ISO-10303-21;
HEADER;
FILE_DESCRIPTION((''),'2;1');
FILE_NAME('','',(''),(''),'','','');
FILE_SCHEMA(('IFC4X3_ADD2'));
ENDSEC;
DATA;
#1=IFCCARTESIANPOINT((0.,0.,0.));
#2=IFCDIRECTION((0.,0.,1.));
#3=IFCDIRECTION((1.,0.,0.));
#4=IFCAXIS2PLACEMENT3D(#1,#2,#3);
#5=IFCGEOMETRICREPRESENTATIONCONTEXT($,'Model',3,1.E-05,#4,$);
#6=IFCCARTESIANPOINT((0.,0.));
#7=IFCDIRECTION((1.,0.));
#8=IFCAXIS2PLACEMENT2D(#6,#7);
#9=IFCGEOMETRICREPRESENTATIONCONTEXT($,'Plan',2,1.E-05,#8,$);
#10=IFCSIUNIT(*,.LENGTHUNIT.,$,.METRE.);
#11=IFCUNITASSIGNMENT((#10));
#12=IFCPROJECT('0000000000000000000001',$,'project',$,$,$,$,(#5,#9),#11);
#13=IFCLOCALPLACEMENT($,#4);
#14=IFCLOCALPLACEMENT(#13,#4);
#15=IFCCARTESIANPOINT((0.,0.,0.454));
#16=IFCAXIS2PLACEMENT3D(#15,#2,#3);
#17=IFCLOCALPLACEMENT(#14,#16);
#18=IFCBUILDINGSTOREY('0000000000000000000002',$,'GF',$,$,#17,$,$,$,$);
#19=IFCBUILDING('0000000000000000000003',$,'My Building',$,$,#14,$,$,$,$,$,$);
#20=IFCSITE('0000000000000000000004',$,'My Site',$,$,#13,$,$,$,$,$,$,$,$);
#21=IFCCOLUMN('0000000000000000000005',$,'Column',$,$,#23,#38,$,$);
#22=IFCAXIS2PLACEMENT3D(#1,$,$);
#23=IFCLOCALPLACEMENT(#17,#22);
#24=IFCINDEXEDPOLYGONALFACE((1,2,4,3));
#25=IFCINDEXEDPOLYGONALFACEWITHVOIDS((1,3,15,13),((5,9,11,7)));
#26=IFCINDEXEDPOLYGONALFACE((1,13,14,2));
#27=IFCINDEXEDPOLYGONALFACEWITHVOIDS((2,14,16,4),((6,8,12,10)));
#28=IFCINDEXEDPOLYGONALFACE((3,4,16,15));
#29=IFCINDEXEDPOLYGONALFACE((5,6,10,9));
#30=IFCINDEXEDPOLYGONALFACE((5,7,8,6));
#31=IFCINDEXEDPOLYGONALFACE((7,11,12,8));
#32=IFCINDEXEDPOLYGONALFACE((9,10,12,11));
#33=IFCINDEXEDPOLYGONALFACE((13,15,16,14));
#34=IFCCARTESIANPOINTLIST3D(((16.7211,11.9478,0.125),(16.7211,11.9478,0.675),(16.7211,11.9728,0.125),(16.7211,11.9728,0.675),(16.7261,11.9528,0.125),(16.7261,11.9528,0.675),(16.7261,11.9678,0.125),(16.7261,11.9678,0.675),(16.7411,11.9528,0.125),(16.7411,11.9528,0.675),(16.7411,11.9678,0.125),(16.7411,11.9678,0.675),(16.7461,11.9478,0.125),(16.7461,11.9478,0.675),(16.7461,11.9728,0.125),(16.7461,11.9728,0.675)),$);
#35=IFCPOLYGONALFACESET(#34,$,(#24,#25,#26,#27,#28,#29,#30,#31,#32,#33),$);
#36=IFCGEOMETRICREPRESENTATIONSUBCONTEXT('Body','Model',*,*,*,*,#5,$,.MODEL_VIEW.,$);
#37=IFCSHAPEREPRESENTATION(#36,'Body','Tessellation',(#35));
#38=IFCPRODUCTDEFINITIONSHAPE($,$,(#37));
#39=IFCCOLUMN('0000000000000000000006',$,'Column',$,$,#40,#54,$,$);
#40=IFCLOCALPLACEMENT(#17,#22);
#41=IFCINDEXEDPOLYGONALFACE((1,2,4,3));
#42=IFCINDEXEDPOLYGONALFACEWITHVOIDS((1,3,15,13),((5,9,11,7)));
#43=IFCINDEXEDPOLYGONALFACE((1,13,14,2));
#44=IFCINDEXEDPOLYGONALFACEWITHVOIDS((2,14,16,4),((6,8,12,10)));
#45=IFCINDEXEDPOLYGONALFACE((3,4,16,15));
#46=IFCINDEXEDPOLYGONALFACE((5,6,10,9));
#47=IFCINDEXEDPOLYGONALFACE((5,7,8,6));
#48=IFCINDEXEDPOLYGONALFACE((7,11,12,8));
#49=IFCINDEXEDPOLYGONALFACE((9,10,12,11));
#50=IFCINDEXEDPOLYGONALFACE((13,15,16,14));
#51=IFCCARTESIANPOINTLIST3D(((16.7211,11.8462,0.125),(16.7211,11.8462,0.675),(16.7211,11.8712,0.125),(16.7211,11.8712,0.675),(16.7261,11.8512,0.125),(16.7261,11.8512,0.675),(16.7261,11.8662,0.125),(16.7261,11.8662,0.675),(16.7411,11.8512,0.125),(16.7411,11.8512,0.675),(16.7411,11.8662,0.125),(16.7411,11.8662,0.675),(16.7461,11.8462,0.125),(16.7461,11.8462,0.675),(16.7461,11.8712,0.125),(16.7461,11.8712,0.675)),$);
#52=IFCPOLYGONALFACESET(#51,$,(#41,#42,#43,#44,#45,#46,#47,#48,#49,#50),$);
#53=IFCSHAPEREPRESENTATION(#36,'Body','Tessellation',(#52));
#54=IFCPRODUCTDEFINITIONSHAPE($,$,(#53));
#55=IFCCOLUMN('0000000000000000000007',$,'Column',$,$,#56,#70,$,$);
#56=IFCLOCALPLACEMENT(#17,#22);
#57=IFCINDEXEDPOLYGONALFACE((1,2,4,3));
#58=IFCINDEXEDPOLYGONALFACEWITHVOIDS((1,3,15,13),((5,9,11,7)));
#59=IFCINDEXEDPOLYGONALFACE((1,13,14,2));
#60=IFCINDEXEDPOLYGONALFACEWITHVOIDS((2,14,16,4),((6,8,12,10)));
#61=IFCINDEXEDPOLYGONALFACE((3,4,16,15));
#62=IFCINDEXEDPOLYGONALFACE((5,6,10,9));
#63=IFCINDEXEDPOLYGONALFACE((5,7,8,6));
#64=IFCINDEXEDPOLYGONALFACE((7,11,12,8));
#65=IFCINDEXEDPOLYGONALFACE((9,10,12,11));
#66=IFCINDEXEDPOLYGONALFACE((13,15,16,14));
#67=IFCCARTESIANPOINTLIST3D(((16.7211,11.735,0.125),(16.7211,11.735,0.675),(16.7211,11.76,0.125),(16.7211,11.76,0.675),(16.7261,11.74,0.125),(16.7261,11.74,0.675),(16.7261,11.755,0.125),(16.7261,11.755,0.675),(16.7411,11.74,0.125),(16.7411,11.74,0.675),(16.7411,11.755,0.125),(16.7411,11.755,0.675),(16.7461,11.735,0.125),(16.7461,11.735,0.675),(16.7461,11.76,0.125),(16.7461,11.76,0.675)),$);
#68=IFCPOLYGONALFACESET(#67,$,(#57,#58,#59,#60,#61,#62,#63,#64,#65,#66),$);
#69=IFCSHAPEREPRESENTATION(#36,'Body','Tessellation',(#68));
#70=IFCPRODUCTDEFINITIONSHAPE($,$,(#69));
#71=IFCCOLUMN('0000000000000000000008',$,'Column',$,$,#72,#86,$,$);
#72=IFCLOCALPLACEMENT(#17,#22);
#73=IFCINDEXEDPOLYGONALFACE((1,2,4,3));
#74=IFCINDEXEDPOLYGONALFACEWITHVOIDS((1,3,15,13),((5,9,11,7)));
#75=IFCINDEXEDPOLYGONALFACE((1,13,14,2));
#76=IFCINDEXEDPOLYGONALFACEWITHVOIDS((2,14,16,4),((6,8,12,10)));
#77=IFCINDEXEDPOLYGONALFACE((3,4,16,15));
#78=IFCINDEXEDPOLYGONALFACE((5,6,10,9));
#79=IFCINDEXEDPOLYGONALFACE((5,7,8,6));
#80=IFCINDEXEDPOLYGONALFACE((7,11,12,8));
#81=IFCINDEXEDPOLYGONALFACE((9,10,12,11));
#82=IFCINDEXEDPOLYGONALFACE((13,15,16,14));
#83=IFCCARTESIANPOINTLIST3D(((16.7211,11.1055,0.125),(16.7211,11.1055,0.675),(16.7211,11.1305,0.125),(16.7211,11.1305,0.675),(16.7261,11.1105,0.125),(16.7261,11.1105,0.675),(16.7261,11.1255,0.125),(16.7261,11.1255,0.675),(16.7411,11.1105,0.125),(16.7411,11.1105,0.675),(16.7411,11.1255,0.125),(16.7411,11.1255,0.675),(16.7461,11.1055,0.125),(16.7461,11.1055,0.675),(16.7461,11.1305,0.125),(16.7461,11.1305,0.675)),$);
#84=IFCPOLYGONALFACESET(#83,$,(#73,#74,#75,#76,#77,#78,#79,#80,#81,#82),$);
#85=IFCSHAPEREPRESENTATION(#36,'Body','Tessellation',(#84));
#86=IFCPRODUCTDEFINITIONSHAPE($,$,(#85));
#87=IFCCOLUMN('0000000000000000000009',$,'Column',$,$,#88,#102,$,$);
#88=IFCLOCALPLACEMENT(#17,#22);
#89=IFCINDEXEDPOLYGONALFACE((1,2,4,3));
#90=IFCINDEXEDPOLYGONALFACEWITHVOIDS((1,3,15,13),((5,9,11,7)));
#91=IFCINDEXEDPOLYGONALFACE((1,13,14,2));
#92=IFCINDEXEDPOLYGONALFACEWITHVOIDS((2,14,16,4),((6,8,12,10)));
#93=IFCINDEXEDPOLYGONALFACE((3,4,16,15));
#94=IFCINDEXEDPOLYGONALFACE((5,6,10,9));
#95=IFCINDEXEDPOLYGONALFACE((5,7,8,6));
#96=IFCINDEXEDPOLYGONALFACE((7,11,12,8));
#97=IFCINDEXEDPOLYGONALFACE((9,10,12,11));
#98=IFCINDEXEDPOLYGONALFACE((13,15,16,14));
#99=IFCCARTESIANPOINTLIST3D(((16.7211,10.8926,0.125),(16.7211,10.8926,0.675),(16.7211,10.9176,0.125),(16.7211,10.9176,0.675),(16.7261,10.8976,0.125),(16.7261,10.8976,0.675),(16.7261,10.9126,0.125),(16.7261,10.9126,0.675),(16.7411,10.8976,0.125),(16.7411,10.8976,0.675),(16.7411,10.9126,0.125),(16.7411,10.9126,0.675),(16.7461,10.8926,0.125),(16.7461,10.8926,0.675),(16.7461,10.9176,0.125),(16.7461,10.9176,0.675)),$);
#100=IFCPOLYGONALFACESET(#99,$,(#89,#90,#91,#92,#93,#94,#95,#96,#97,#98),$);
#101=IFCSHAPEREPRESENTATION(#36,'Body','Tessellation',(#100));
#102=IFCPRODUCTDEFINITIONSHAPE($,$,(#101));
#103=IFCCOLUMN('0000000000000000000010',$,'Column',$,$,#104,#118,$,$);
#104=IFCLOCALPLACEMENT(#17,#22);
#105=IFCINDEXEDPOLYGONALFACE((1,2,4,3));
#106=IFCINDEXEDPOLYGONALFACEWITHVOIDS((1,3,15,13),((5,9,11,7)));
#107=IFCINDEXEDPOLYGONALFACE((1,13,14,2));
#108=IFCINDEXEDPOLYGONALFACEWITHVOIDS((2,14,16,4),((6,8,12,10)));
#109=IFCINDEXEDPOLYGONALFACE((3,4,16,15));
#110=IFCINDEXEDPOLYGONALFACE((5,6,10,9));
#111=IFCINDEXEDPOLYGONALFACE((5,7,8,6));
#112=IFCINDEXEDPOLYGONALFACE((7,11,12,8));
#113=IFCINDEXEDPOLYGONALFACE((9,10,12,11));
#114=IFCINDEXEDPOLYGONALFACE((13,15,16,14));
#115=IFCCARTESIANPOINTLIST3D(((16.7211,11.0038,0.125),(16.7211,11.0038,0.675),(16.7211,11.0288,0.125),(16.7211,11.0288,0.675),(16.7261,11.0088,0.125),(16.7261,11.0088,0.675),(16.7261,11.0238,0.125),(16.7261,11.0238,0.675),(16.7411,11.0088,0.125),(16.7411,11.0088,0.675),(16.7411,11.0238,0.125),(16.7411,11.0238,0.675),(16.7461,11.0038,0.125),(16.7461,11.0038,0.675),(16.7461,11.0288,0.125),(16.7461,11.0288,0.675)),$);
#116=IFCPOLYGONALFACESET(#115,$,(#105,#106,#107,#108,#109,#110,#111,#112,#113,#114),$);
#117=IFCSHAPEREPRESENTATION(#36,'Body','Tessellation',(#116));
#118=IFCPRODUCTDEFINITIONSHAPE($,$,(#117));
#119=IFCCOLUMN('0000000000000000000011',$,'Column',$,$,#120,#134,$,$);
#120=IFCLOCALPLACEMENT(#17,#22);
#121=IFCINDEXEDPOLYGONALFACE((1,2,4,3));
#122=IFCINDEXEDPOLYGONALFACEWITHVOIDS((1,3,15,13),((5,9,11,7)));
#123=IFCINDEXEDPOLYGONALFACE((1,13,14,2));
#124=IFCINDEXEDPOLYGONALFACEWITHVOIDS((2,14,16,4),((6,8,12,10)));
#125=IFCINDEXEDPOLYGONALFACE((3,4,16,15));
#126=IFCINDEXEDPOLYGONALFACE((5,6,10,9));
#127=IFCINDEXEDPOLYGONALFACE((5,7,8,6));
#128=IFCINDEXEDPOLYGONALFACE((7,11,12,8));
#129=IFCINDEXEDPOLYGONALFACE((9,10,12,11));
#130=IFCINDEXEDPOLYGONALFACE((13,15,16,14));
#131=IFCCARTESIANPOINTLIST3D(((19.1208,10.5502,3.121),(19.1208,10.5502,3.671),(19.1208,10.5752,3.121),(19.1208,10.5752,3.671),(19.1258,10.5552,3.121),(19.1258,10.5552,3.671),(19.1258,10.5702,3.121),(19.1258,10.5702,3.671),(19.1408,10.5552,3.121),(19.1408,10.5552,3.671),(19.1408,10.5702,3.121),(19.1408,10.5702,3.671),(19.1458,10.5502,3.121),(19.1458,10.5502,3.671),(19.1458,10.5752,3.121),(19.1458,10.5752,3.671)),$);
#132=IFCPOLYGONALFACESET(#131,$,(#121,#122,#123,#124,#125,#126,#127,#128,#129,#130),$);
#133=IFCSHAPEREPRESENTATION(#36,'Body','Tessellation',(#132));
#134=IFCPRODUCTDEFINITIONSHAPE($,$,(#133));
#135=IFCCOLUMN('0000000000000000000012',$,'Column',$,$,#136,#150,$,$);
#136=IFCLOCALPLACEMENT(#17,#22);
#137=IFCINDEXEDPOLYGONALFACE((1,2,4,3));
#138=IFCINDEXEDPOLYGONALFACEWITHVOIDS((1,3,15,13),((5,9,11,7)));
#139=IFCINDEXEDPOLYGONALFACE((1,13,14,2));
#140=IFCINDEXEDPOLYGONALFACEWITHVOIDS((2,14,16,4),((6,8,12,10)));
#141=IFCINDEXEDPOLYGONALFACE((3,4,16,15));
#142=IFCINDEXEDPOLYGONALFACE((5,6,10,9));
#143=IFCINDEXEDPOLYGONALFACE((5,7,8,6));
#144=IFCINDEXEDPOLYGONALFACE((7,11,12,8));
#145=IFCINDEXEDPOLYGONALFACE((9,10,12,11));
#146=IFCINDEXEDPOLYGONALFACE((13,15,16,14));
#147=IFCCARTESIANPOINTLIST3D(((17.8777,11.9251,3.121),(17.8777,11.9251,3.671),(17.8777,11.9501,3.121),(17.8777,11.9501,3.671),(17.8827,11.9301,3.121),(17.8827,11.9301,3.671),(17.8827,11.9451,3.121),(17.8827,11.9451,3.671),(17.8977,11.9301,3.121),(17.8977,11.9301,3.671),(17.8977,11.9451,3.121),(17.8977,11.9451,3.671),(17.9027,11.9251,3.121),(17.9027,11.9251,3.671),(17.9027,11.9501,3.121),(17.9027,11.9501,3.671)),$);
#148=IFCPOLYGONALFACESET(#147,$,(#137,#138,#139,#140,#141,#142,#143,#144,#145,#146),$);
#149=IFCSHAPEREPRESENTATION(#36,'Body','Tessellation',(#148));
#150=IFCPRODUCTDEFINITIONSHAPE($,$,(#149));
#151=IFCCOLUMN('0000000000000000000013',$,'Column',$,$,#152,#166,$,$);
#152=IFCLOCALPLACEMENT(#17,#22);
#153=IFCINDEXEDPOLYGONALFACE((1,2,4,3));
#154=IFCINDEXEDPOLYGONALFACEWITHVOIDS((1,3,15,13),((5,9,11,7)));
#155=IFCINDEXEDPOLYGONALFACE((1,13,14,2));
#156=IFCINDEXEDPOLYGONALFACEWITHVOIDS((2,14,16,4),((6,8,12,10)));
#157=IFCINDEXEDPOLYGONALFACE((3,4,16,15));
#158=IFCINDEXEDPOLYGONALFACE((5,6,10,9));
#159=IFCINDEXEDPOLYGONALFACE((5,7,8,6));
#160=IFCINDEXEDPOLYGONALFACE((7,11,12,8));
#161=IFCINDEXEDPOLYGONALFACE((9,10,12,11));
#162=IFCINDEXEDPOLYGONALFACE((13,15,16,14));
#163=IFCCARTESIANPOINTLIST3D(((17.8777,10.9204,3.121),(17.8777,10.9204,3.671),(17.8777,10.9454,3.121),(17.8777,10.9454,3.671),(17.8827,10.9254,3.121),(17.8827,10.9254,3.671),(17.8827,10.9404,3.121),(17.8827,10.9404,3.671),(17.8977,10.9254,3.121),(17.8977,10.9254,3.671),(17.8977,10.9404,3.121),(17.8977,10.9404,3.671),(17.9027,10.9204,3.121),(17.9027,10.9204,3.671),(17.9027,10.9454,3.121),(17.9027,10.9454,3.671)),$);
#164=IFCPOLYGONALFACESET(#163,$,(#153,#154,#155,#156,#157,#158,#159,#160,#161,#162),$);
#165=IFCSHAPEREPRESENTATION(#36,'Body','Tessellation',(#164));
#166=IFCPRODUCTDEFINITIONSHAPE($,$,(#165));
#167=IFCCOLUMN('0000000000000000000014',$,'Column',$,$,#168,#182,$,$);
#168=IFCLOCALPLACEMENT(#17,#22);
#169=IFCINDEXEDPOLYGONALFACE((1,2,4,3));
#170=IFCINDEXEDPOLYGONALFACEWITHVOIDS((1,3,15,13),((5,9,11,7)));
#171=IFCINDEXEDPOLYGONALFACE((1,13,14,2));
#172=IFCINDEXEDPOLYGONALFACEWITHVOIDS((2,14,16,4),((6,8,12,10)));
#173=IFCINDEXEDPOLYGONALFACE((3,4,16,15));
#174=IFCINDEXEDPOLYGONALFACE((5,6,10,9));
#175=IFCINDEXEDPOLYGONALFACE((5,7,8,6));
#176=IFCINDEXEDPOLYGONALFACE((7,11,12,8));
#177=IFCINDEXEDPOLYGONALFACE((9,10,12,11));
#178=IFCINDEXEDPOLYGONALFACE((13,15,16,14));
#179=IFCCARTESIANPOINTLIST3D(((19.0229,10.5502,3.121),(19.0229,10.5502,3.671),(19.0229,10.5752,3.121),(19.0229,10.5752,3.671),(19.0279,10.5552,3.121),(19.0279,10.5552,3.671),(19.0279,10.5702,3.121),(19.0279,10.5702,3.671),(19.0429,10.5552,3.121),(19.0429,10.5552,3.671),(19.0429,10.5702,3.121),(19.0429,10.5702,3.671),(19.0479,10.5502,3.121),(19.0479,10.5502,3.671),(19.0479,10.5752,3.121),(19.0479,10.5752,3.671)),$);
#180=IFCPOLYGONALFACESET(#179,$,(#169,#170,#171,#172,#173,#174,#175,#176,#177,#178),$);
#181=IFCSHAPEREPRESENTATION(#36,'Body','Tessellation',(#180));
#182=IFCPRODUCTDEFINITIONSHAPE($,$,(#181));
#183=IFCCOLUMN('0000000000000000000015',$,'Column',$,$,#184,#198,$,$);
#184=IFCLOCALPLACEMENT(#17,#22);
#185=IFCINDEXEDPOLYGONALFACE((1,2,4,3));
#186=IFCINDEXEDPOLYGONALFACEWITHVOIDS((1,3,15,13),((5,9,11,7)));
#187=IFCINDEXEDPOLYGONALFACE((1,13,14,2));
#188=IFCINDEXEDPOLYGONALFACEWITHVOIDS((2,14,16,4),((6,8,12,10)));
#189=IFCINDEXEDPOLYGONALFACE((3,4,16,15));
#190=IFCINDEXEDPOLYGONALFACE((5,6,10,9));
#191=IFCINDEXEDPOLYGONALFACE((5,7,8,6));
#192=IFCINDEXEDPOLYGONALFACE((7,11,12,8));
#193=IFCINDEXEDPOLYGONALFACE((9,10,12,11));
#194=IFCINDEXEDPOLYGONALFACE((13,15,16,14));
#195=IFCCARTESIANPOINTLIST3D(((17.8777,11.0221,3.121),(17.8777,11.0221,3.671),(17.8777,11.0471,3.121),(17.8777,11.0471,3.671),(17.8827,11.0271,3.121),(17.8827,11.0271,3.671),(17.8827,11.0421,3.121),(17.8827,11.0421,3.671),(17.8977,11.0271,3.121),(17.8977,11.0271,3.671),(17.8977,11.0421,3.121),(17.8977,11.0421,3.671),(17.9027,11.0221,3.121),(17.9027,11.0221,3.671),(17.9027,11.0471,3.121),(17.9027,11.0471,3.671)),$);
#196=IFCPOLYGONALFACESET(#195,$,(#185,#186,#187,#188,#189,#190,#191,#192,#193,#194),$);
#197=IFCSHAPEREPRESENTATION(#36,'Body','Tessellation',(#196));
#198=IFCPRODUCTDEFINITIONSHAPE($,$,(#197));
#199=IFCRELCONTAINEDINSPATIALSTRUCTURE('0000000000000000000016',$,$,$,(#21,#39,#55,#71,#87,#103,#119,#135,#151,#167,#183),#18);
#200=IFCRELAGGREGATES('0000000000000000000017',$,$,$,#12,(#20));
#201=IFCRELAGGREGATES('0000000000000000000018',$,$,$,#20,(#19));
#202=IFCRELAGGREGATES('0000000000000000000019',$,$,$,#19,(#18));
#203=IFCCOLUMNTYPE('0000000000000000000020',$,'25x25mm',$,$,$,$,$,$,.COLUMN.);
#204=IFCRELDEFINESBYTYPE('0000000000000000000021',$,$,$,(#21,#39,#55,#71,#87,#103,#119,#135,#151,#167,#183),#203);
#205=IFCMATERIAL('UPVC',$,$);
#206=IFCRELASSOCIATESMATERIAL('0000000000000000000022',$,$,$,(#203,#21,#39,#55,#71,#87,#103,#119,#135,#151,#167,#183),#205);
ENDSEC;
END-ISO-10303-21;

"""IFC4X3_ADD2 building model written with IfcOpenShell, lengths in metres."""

from ifc_helpers import new_model, si_unit, frame, origin_with_axes, origin_2d_with_axis, place, context, subcontext, project, spatial, hollow_rectangle, extrude, material, material_profile, profile_set, profile_usage, type_object, element, save


model = new_model("IFC4X3_ADD2")

# Units and contexts
model_context = context("Model", 3, precision=1e-05, world=origin_with_axes())
plan_context = context("Plan", 2, precision=1e-05, world=origin_2d_with_axis())
body_context = subcontext(model_context, "Body", "Model", "MODEL_VIEW")
ifc_project = project(units=[si_unit("LENGTHUNIT", "METRE")], contexts=[model_context, plan_context])

# Site, building, storey
site_placement = place(None, origin_with_axes())
site = spatial("IfcSite", under=ifc_project, at=site_placement, Name="My Site")
building_placement = place(site_placement, origin_with_axes())
building = spatial("IfcBuilding", under=site, at=building_placement, Name="My Building")
storey_placement = place(building_placement, frame((0.0, 0.0, 0.454), z_axis=(0.0, 0.0, 1.0), x_axis=(1.0, 0.0, 0.0)))
storey = spatial("IfcBuildingStorey", under=building, at=storey_placement, Name="GF")

# Columns
ifc_material_1 = material(Name="UPVC")
ifc_material_profile_1 = material_profile(ifc_material_1, hollow_rectangle(XDim=0.025, YDim=0.025, WallThickness=0.005))
ifc_profile_set_1 = profile_set([ifc_material_profile_1])
ifc_profile_usage_1 = profile_usage(ifc_profile_set_1)
column_type_1 = type_object("IfcColumnType", Name="25x25mm", PredefinedType="COLUMN", material=ifc_profile_set_1)
column_1_placement = place(storey_placement, frame((16.7336, 11.9603, 0.125), z_axis=(0.0, 0.0, 1.0), x_axis=(0.0, -1.0, 0.0)))
element("IfcColumn", 1, at=column_1_placement, inside=storey, type_object=column_type_1, material=ifc_profile_usage_1, Name="Column", context=body_context, shape_type="SweptSolid", body=[
    extrude(hollow_rectangle(XDim=0.025, YDim=0.025, WallThickness=0.005), origin_with_axes(), (0.0, 0.0, 1.0), 0.55),
])
ifc_profile_usage_2 = profile_usage(ifc_profile_set_1)
column_2_placement = place(storey_placement, frame((16.7336, 11.8587, 0.125), z_axis=(0.0, 0.0, 1.0), x_axis=(0.0, -1.0, 0.0)))
element("IfcColumn", 2, at=column_2_placement, inside=storey, type_object=column_type_1, material=ifc_profile_usage_2, Name="Column", context=body_context, shape_type="SweptSolid", body=[
    extrude(hollow_rectangle(XDim=0.025, YDim=0.025, WallThickness=0.005), origin_with_axes(), (0.0, 0.0, 1.0), 0.55),
])
ifc_profile_usage_3 = profile_usage(ifc_profile_set_1)
column_3_placement = place(storey_placement, frame((16.7336, 11.7475, 0.125), z_axis=(0.0, 0.0, 1.0), x_axis=(0.0, -1.0, 0.0)))
element("IfcColumn", 3, at=column_3_placement, inside=storey, type_object=column_type_1, material=ifc_profile_usage_3, Name="Column", context=body_context, shape_type="SweptSolid", body=[
    extrude(hollow_rectangle(XDim=0.025, YDim=0.025, WallThickness=0.005), origin_with_axes(), (0.0, 0.0, 1.0), 0.55),
])
ifc_profile_usage_4 = profile_usage(ifc_profile_set_1)
column_4_placement = place(storey_placement, frame((16.7336, 11.118, 0.125), z_axis=(0.0, 0.0, 1.0), x_axis=(0.0, -1.0, 0.0)))
element("IfcColumn", 4, at=column_4_placement, inside=storey, type_object=column_type_1, material=ifc_profile_usage_4, Name="Column", context=body_context, shape_type="SweptSolid", body=[
    extrude(hollow_rectangle(XDim=0.025, YDim=0.025, WallThickness=0.005), origin_with_axes(), (0.0, 0.0, 1.0), 0.55),
])
ifc_profile_usage_5 = profile_usage(ifc_profile_set_1)
column_5_placement = place(storey_placement, frame((16.7336, 10.9051, 0.125), z_axis=(0.0, 0.0, 1.0), x_axis=(0.0, -1.0, 0.0)))
element("IfcColumn", 5, at=column_5_placement, inside=storey, type_object=column_type_1, material=ifc_profile_usage_5, Name="Column", context=body_context, shape_type="SweptSolid", body=[
    extrude(hollow_rectangle(XDim=0.025, YDim=0.025, WallThickness=0.005), origin_with_axes(), (0.0, 0.0, 1.0), 0.55),
])
ifc_profile_usage_6 = profile_usage(ifc_profile_set_1)
column_6_placement = place(storey_placement, frame((16.7336, 11.0163, 0.125), z_axis=(0.0, 0.0, 1.0), x_axis=(0.0, -1.0, 0.0)))
element("IfcColumn", 6, at=column_6_placement, inside=storey, type_object=column_type_1, material=ifc_profile_usage_6, Name="Column", context=body_context, shape_type="SweptSolid", body=[
    extrude(hollow_rectangle(XDim=0.025, YDim=0.025, WallThickness=0.005), origin_with_axes(), (0.0, 0.0, 1.0), 0.55),
])
ifc_profile_usage_7 = profile_usage(ifc_profile_set_1)
column_7_placement = place(storey_placement, frame((19.1333, 10.5627, 3.121), z_axis=(0.0, 0.0, 1.0), x_axis=(0.0, -1.0, 0.0)))
element("IfcColumn", 7, at=column_7_placement, inside=storey, type_object=column_type_1, material=ifc_profile_usage_7, Name="Column", context=body_context, shape_type="SweptSolid", body=[
    extrude(hollow_rectangle(XDim=0.025, YDim=0.025, WallThickness=0.005), origin_with_axes(), (0.0, 0.0, 1.0), 0.55),
])
ifc_profile_usage_8 = profile_usage(ifc_profile_set_1)
column_8_placement = place(storey_placement, frame((17.8902, 11.9376, 3.121), z_axis=(0.0, 0.0, 1.0), x_axis=(0.0, -1.0, 0.0)))
element("IfcColumn", 8, at=column_8_placement, inside=storey, type_object=column_type_1, material=ifc_profile_usage_8, Name="Column", context=body_context, shape_type="SweptSolid", body=[
    extrude(hollow_rectangle(XDim=0.025, YDim=0.025, WallThickness=0.005), origin_with_axes(), (0.0, 0.0, 1.0), 0.55),
])
ifc_profile_usage_9 = profile_usage(ifc_profile_set_1)
column_9_placement = place(storey_placement, frame((17.8902, 10.9329, 3.121), z_axis=(0.0, 0.0, 1.0), x_axis=(0.0, -1.0, 0.0)))
element("IfcColumn", 9, at=column_9_placement, inside=storey, type_object=column_type_1, material=ifc_profile_usage_9, Name="Column", context=body_context, shape_type="SweptSolid", body=[
    extrude(hollow_rectangle(XDim=0.025, YDim=0.025, WallThickness=0.005), origin_with_axes(), (0.0, 0.0, 1.0), 0.55),
])
ifc_profile_usage_10 = profile_usage(ifc_profile_set_1)
column_10_placement = place(storey_placement, frame((19.0354, 10.5627, 3.121), z_axis=(0.0, 0.0, 1.0), x_axis=(0.0, -1.0, 0.0)))
element("IfcColumn", 10, at=column_10_placement, inside=storey, type_object=column_type_1, material=ifc_profile_usage_10, Name="Column", context=body_context, shape_type="SweptSolid", body=[
    extrude(hollow_rectangle(XDim=0.025, YDim=0.025, WallThickness=0.005), origin_with_axes(), (0.0, 0.0, 1.0), 0.55),
])
ifc_profile_usage_11 = profile_usage(ifc_profile_set_1)
column_11_placement = place(storey_placement, frame((17.8902, 11.0346, 3.121), z_axis=(0.0, 0.0, 1.0), x_axis=(0.0, -1.0, 0.0)))
element("IfcColumn", 11, at=column_11_placement, inside=storey, type_object=column_type_1, material=ifc_profile_usage_11, Name="Column", context=body_context, shape_type="SweptSolid", body=[
    extrude(hollow_rectangle(XDim=0.025, YDim=0.025, WallThickness=0.005), origin_with_axes(), (0.0, 0.0, 1.0), 0.55),
])

save(model, "model.ifc")
